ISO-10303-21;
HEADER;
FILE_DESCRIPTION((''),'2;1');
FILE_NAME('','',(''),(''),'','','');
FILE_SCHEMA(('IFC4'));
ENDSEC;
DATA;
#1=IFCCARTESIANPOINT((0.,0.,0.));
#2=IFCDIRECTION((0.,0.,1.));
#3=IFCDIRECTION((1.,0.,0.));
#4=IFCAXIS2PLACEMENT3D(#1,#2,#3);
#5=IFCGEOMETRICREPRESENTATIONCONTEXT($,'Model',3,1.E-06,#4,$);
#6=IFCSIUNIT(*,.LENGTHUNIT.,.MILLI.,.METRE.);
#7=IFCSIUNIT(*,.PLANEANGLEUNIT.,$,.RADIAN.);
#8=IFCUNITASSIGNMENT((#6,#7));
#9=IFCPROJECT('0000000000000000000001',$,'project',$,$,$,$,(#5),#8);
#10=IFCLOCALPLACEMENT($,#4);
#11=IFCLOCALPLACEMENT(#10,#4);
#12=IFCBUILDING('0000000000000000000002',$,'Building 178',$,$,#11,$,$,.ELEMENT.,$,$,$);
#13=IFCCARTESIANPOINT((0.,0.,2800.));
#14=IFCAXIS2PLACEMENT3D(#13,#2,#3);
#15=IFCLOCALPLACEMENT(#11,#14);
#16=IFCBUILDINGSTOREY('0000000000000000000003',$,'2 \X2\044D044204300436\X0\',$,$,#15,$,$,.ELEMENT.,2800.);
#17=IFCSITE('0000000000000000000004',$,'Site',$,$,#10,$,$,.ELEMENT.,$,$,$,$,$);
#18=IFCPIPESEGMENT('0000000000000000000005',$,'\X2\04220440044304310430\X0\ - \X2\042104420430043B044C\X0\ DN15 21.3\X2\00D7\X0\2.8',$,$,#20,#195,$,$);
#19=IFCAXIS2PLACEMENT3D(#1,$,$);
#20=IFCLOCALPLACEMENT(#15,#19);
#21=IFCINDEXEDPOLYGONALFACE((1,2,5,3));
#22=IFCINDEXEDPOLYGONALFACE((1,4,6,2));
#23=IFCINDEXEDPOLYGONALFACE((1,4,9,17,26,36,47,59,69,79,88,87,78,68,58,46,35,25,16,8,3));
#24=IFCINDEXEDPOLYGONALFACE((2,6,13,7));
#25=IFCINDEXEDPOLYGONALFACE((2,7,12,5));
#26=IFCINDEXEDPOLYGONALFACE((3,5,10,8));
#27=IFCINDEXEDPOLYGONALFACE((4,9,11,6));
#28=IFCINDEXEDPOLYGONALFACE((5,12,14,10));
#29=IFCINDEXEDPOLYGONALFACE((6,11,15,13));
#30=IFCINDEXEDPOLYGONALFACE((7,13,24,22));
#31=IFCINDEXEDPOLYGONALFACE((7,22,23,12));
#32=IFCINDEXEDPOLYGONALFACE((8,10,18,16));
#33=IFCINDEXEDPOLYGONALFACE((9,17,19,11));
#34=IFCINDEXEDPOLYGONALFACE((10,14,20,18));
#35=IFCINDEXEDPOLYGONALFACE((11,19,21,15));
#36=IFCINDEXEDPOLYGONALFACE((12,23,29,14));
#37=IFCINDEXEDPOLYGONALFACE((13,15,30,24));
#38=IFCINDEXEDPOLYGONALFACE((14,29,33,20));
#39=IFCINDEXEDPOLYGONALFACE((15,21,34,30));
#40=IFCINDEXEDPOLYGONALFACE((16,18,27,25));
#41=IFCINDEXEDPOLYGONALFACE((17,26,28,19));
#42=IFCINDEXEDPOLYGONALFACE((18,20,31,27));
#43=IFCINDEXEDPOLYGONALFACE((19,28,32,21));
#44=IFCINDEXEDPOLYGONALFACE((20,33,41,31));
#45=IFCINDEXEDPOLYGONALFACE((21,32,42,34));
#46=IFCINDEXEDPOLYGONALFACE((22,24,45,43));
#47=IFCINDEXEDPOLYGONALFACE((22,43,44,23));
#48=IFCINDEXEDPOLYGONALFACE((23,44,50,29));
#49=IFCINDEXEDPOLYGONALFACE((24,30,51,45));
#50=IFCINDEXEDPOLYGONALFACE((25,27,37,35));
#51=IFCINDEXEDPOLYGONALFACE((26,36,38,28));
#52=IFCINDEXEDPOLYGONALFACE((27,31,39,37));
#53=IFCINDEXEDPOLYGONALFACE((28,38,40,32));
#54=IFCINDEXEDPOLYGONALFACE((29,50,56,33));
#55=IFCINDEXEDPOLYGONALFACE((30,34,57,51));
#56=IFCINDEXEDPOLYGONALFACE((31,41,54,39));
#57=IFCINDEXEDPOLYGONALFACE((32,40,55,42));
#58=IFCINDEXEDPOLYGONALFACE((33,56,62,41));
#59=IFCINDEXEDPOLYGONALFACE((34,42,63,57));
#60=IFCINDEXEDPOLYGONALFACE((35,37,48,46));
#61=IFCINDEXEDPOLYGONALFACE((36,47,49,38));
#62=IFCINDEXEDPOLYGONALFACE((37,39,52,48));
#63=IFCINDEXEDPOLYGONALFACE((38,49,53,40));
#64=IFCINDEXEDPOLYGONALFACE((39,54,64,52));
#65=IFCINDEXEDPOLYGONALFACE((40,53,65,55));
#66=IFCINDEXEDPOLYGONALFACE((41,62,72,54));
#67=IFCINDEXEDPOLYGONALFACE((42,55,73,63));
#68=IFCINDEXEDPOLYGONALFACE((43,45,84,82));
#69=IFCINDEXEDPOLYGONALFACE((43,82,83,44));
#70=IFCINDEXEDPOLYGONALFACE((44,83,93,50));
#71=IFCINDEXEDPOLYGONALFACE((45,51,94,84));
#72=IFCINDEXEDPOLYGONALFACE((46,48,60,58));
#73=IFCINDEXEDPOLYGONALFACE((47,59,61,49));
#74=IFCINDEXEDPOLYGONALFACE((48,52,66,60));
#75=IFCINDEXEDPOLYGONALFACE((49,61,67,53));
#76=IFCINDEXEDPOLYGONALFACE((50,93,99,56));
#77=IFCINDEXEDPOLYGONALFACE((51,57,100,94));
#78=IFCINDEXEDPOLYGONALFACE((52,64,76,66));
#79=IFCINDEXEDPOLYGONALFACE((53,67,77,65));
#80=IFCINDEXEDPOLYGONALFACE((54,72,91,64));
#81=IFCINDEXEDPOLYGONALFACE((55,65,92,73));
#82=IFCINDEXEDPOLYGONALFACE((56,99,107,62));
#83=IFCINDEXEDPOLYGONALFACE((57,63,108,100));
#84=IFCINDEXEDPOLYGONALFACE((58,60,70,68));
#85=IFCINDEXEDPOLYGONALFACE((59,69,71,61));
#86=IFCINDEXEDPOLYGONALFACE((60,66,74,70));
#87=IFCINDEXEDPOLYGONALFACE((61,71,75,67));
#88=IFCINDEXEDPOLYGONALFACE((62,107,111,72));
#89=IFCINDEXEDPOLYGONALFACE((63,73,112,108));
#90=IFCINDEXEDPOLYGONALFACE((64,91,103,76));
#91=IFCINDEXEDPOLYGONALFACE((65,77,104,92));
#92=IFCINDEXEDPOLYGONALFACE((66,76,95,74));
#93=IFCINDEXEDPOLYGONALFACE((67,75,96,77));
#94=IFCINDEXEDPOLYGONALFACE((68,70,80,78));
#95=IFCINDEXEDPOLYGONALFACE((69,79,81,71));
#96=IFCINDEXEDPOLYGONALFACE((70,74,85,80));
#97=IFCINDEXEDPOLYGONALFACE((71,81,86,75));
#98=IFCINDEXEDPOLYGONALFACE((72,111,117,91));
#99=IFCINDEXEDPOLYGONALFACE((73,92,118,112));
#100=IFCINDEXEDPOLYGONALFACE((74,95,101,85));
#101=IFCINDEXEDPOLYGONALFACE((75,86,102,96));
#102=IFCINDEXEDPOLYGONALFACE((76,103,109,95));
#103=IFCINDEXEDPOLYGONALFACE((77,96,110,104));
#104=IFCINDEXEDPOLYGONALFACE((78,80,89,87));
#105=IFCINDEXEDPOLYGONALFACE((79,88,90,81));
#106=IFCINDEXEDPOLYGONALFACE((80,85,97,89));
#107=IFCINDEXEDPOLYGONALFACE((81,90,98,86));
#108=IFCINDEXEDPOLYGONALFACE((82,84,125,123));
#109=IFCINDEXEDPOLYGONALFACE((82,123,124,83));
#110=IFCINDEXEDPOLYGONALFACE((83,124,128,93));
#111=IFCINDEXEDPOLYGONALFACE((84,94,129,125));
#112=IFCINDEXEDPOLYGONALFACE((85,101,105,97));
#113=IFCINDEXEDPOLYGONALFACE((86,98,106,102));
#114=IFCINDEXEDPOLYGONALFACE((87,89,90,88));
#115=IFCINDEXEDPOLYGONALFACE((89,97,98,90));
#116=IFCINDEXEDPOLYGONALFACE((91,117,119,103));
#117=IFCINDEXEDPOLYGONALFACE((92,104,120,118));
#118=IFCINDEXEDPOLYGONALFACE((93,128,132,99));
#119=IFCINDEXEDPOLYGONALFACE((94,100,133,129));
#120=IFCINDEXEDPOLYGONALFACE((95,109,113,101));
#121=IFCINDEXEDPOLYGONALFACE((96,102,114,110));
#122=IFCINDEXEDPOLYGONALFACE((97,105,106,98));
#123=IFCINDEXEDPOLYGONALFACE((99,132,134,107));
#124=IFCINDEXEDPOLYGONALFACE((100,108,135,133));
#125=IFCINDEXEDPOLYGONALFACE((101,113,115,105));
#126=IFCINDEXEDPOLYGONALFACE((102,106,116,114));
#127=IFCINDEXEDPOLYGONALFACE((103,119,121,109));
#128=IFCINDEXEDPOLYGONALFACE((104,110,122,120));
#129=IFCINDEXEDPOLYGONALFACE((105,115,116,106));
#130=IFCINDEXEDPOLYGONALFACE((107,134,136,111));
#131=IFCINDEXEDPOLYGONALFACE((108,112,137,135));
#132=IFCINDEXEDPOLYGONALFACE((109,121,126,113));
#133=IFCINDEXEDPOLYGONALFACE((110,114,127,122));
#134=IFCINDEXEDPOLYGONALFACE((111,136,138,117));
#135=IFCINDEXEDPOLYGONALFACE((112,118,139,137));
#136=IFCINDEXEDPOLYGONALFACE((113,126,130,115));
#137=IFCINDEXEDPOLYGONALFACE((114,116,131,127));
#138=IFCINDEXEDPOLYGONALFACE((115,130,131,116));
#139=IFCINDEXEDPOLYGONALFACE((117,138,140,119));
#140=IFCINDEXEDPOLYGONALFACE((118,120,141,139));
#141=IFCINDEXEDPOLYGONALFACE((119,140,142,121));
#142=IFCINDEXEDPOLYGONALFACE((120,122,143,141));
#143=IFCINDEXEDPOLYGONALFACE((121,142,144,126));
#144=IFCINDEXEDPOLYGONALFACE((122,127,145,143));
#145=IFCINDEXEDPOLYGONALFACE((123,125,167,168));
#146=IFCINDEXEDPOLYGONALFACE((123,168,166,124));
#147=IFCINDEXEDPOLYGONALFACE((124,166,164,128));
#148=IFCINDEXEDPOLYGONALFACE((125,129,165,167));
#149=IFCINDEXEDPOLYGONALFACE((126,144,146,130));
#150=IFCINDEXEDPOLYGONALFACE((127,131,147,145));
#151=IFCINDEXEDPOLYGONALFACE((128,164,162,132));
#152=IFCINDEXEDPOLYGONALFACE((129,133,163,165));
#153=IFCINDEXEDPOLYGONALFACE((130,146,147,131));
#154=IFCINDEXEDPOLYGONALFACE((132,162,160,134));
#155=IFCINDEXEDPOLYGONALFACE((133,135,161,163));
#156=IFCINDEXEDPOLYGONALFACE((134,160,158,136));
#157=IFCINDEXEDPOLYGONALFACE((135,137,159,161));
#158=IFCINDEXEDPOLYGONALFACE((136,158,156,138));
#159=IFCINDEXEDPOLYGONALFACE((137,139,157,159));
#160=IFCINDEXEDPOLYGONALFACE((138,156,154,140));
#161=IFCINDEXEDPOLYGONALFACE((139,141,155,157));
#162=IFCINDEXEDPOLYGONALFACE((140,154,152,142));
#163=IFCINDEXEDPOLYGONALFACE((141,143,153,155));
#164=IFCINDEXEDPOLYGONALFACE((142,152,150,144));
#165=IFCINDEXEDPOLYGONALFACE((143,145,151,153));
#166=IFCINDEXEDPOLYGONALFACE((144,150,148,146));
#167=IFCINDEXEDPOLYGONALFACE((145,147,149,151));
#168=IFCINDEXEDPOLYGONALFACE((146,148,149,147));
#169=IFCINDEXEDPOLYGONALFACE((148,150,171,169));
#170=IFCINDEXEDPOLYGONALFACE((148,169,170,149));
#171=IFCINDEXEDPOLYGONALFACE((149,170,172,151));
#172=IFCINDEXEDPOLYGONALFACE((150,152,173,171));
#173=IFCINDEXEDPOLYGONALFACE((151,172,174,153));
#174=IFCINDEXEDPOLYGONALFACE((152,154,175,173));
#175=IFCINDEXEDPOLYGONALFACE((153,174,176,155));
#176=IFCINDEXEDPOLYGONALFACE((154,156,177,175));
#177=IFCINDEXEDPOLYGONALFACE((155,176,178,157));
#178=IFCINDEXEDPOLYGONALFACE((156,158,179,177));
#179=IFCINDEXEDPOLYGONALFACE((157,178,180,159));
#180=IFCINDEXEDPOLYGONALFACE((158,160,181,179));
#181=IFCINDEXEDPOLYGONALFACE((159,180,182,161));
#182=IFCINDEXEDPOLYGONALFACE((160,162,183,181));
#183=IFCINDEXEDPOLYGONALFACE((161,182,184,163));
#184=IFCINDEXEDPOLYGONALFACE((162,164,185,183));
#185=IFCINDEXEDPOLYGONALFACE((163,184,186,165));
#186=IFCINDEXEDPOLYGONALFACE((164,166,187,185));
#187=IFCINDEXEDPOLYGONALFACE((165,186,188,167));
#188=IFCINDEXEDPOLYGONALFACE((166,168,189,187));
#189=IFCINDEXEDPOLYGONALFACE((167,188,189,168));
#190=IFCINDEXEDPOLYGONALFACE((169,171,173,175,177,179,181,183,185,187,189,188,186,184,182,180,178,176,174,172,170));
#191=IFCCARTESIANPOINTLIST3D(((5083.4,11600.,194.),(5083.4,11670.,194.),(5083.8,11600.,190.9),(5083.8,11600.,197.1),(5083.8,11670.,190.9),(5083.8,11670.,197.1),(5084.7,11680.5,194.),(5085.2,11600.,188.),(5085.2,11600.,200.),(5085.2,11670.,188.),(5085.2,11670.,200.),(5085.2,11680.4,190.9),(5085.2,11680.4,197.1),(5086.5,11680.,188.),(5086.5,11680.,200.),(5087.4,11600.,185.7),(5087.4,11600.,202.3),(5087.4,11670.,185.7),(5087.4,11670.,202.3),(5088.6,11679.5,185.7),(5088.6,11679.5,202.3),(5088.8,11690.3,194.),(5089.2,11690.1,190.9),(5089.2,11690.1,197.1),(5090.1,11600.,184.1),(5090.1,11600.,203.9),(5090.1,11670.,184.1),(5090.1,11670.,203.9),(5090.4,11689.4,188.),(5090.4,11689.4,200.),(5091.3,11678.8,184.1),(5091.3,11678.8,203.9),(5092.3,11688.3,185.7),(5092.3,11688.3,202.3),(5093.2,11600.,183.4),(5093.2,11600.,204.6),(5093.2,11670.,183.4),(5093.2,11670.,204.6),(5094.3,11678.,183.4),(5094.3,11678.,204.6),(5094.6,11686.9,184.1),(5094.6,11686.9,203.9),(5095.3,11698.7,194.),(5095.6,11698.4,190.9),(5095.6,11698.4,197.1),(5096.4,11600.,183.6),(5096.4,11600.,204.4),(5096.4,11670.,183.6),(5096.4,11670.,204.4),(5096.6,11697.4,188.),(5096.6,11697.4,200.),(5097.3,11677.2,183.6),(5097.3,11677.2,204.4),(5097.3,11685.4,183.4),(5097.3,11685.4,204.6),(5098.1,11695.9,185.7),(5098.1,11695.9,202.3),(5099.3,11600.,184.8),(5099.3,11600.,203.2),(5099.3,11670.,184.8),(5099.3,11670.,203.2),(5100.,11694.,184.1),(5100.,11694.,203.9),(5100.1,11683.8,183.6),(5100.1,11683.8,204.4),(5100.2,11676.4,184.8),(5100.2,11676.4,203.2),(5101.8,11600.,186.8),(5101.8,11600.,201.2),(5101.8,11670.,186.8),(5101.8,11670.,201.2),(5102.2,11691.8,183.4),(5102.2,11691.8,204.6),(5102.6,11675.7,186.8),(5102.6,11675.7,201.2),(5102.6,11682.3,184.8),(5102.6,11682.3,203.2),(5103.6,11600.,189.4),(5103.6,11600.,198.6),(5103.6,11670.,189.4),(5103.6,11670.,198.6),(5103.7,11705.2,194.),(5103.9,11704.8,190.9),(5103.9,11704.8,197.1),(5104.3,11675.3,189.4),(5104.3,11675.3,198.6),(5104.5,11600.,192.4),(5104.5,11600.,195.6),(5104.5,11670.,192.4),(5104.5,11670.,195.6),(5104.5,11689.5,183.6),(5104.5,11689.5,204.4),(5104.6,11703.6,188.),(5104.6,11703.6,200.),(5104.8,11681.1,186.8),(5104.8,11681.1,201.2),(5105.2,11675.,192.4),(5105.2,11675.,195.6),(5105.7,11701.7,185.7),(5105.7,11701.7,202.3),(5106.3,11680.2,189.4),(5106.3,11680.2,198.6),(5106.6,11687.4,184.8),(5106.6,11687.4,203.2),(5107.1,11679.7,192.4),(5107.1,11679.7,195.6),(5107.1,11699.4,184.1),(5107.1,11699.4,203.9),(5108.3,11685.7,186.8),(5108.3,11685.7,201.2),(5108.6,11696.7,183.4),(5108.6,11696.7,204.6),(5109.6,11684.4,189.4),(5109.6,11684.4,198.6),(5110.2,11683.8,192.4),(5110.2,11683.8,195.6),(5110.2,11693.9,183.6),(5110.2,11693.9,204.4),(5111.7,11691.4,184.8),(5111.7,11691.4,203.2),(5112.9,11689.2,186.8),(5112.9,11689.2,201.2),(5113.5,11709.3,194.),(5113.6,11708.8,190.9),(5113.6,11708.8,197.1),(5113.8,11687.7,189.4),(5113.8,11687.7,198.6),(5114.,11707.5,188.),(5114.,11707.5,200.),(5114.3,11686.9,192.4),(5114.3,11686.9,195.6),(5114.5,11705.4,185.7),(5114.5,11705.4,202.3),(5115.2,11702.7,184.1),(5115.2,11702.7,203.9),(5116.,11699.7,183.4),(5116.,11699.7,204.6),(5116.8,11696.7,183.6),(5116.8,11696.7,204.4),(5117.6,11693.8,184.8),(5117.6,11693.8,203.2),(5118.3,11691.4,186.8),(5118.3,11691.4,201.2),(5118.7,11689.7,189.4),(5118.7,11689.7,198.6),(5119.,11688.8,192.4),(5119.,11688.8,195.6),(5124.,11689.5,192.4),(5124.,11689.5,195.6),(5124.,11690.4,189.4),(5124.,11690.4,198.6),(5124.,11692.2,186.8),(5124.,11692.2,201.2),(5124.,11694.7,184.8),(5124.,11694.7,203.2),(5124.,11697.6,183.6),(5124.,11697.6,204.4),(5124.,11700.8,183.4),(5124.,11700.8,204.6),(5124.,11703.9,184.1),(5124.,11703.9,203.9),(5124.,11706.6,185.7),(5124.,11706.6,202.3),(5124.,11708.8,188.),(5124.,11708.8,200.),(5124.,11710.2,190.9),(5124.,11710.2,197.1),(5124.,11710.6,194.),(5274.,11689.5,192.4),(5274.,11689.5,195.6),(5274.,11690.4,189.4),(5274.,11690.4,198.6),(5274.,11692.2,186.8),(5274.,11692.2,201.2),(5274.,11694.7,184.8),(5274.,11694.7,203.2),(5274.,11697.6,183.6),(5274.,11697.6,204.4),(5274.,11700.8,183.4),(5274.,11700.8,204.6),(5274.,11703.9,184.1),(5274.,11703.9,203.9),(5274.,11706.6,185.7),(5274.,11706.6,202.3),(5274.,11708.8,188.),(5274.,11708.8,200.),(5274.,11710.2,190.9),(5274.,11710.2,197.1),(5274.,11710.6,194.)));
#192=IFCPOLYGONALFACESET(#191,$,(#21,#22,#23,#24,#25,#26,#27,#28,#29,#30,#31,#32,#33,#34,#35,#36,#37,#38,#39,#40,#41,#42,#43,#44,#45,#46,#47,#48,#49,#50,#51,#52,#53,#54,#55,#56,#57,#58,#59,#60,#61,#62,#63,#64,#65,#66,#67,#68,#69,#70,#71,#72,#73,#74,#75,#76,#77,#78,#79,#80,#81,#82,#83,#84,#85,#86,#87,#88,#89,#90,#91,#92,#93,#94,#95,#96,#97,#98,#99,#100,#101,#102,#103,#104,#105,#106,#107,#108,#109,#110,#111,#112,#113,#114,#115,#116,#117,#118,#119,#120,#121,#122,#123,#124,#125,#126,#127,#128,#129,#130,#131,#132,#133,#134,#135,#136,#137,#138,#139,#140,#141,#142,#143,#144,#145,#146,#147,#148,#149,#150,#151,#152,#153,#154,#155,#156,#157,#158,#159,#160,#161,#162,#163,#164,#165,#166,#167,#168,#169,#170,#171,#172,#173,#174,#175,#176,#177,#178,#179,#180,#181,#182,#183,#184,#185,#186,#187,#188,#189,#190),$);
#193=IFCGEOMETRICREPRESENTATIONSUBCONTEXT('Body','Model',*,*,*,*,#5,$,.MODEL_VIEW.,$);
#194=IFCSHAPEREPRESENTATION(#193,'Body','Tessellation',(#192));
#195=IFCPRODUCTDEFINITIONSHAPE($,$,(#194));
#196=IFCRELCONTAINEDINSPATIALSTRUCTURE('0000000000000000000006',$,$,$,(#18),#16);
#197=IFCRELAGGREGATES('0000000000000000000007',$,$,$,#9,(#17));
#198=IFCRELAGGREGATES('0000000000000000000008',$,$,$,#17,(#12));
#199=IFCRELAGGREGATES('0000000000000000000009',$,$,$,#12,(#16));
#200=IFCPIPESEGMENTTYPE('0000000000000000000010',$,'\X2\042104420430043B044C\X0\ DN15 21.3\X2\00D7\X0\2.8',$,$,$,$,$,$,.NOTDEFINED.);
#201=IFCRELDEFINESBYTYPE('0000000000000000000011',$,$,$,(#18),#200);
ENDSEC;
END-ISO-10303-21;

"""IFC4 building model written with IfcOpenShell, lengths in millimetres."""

from ifc_helpers import new_model, entity, si_unit, frame, origin_with_axes, place, context, subcontext, project, spatial, source, transform, mapped, type_object, element, save


model = new_model("IFC4")

# Units and contexts
model_context = context("Model", 3, precision=1e-06, world=origin_with_axes())
body_context = subcontext(model_context, "Body", "Model", "MODEL_VIEW")
ifc_project = project(units=[si_unit("LENGTHUNIT", "METRE", prefix="MILLI"), si_unit("PLANEANGLEUNIT", "RADIAN")], contexts=[model_context])

# Site, building, storey
site_placement = place(None, origin_with_axes())
site = spatial("IfcSite", under=ifc_project, at=site_placement, Name="Site", CompositionType="ELEMENT")
building_placement = place(site_placement, origin_with_axes())
building = spatial("IfcBuilding", under=site, at=building_placement, Name="Building 178", CompositionType="ELEMENT")
storey_placement = place(building_placement, frame((0.0, 0.0, 2800.0), z_axis=(0.0, 0.0, 1.0), x_axis=(1.0, 0.0, 0.0)))
storey = spatial("IfcBuildingStorey", under=building, at=storey_placement, Name="2 этаж", CompositionType="ELEMENT", Elevation=2800.0)

# Pipe segment
pipe_segment_type = type_object("IfcPipeSegmentType", Name="Сталь DN15 21.3×2.8", PredefinedType="NOTDEFINED")
shared_shape_1 = source(origin_with_axes(), body_context, "Body", "AdvancedSweptSolid", [
    entity("IfcSweptDiskSolid", entity("IfcIndexedPolyCurve", entity("IfcCartesianPointList3D", [[0.0, 0.0, 0.0], [0.0, 0.0, -70.0], [8.8, 0.0, -91.2], [30.0, 0.0, -100.0], [180.0, 0.0, -100.0]]), [entity("IfcLineIndex", [1, 2]), entity("IfcArcIndex", [2, 3, 4]), entity("IfcLineIndex", [4, 5])]), 10.7),
])
for number, where, z_axis, x_axis, name in (
    (1, (5094.0, 11600.0, 194.0), (0.0, -1.0, 0.0), (1.0, 0.0, 0.0), "Труба - Сталь DN15 21.3×2.8"),
):
    element("IfcPipeSegment", number, at=place(storey_placement, frame(where, z_axis=z_axis, x_axis=x_axis)), inside=storey, type_object=pipe_segment_type, Name=name, context=body_context, shape_type="MappedRepresentation", body=[
        mapped(shared_shape_1, transform((0.0, 0.0, 0.0), x_axis=(1.0, 0.0, 0.0), y_axis=(0.0, 1.0, 0.0), z_axis=(0.0, 0.0, 1.0), scale=1.0)),
    ])

save(model, "model.ifc")
